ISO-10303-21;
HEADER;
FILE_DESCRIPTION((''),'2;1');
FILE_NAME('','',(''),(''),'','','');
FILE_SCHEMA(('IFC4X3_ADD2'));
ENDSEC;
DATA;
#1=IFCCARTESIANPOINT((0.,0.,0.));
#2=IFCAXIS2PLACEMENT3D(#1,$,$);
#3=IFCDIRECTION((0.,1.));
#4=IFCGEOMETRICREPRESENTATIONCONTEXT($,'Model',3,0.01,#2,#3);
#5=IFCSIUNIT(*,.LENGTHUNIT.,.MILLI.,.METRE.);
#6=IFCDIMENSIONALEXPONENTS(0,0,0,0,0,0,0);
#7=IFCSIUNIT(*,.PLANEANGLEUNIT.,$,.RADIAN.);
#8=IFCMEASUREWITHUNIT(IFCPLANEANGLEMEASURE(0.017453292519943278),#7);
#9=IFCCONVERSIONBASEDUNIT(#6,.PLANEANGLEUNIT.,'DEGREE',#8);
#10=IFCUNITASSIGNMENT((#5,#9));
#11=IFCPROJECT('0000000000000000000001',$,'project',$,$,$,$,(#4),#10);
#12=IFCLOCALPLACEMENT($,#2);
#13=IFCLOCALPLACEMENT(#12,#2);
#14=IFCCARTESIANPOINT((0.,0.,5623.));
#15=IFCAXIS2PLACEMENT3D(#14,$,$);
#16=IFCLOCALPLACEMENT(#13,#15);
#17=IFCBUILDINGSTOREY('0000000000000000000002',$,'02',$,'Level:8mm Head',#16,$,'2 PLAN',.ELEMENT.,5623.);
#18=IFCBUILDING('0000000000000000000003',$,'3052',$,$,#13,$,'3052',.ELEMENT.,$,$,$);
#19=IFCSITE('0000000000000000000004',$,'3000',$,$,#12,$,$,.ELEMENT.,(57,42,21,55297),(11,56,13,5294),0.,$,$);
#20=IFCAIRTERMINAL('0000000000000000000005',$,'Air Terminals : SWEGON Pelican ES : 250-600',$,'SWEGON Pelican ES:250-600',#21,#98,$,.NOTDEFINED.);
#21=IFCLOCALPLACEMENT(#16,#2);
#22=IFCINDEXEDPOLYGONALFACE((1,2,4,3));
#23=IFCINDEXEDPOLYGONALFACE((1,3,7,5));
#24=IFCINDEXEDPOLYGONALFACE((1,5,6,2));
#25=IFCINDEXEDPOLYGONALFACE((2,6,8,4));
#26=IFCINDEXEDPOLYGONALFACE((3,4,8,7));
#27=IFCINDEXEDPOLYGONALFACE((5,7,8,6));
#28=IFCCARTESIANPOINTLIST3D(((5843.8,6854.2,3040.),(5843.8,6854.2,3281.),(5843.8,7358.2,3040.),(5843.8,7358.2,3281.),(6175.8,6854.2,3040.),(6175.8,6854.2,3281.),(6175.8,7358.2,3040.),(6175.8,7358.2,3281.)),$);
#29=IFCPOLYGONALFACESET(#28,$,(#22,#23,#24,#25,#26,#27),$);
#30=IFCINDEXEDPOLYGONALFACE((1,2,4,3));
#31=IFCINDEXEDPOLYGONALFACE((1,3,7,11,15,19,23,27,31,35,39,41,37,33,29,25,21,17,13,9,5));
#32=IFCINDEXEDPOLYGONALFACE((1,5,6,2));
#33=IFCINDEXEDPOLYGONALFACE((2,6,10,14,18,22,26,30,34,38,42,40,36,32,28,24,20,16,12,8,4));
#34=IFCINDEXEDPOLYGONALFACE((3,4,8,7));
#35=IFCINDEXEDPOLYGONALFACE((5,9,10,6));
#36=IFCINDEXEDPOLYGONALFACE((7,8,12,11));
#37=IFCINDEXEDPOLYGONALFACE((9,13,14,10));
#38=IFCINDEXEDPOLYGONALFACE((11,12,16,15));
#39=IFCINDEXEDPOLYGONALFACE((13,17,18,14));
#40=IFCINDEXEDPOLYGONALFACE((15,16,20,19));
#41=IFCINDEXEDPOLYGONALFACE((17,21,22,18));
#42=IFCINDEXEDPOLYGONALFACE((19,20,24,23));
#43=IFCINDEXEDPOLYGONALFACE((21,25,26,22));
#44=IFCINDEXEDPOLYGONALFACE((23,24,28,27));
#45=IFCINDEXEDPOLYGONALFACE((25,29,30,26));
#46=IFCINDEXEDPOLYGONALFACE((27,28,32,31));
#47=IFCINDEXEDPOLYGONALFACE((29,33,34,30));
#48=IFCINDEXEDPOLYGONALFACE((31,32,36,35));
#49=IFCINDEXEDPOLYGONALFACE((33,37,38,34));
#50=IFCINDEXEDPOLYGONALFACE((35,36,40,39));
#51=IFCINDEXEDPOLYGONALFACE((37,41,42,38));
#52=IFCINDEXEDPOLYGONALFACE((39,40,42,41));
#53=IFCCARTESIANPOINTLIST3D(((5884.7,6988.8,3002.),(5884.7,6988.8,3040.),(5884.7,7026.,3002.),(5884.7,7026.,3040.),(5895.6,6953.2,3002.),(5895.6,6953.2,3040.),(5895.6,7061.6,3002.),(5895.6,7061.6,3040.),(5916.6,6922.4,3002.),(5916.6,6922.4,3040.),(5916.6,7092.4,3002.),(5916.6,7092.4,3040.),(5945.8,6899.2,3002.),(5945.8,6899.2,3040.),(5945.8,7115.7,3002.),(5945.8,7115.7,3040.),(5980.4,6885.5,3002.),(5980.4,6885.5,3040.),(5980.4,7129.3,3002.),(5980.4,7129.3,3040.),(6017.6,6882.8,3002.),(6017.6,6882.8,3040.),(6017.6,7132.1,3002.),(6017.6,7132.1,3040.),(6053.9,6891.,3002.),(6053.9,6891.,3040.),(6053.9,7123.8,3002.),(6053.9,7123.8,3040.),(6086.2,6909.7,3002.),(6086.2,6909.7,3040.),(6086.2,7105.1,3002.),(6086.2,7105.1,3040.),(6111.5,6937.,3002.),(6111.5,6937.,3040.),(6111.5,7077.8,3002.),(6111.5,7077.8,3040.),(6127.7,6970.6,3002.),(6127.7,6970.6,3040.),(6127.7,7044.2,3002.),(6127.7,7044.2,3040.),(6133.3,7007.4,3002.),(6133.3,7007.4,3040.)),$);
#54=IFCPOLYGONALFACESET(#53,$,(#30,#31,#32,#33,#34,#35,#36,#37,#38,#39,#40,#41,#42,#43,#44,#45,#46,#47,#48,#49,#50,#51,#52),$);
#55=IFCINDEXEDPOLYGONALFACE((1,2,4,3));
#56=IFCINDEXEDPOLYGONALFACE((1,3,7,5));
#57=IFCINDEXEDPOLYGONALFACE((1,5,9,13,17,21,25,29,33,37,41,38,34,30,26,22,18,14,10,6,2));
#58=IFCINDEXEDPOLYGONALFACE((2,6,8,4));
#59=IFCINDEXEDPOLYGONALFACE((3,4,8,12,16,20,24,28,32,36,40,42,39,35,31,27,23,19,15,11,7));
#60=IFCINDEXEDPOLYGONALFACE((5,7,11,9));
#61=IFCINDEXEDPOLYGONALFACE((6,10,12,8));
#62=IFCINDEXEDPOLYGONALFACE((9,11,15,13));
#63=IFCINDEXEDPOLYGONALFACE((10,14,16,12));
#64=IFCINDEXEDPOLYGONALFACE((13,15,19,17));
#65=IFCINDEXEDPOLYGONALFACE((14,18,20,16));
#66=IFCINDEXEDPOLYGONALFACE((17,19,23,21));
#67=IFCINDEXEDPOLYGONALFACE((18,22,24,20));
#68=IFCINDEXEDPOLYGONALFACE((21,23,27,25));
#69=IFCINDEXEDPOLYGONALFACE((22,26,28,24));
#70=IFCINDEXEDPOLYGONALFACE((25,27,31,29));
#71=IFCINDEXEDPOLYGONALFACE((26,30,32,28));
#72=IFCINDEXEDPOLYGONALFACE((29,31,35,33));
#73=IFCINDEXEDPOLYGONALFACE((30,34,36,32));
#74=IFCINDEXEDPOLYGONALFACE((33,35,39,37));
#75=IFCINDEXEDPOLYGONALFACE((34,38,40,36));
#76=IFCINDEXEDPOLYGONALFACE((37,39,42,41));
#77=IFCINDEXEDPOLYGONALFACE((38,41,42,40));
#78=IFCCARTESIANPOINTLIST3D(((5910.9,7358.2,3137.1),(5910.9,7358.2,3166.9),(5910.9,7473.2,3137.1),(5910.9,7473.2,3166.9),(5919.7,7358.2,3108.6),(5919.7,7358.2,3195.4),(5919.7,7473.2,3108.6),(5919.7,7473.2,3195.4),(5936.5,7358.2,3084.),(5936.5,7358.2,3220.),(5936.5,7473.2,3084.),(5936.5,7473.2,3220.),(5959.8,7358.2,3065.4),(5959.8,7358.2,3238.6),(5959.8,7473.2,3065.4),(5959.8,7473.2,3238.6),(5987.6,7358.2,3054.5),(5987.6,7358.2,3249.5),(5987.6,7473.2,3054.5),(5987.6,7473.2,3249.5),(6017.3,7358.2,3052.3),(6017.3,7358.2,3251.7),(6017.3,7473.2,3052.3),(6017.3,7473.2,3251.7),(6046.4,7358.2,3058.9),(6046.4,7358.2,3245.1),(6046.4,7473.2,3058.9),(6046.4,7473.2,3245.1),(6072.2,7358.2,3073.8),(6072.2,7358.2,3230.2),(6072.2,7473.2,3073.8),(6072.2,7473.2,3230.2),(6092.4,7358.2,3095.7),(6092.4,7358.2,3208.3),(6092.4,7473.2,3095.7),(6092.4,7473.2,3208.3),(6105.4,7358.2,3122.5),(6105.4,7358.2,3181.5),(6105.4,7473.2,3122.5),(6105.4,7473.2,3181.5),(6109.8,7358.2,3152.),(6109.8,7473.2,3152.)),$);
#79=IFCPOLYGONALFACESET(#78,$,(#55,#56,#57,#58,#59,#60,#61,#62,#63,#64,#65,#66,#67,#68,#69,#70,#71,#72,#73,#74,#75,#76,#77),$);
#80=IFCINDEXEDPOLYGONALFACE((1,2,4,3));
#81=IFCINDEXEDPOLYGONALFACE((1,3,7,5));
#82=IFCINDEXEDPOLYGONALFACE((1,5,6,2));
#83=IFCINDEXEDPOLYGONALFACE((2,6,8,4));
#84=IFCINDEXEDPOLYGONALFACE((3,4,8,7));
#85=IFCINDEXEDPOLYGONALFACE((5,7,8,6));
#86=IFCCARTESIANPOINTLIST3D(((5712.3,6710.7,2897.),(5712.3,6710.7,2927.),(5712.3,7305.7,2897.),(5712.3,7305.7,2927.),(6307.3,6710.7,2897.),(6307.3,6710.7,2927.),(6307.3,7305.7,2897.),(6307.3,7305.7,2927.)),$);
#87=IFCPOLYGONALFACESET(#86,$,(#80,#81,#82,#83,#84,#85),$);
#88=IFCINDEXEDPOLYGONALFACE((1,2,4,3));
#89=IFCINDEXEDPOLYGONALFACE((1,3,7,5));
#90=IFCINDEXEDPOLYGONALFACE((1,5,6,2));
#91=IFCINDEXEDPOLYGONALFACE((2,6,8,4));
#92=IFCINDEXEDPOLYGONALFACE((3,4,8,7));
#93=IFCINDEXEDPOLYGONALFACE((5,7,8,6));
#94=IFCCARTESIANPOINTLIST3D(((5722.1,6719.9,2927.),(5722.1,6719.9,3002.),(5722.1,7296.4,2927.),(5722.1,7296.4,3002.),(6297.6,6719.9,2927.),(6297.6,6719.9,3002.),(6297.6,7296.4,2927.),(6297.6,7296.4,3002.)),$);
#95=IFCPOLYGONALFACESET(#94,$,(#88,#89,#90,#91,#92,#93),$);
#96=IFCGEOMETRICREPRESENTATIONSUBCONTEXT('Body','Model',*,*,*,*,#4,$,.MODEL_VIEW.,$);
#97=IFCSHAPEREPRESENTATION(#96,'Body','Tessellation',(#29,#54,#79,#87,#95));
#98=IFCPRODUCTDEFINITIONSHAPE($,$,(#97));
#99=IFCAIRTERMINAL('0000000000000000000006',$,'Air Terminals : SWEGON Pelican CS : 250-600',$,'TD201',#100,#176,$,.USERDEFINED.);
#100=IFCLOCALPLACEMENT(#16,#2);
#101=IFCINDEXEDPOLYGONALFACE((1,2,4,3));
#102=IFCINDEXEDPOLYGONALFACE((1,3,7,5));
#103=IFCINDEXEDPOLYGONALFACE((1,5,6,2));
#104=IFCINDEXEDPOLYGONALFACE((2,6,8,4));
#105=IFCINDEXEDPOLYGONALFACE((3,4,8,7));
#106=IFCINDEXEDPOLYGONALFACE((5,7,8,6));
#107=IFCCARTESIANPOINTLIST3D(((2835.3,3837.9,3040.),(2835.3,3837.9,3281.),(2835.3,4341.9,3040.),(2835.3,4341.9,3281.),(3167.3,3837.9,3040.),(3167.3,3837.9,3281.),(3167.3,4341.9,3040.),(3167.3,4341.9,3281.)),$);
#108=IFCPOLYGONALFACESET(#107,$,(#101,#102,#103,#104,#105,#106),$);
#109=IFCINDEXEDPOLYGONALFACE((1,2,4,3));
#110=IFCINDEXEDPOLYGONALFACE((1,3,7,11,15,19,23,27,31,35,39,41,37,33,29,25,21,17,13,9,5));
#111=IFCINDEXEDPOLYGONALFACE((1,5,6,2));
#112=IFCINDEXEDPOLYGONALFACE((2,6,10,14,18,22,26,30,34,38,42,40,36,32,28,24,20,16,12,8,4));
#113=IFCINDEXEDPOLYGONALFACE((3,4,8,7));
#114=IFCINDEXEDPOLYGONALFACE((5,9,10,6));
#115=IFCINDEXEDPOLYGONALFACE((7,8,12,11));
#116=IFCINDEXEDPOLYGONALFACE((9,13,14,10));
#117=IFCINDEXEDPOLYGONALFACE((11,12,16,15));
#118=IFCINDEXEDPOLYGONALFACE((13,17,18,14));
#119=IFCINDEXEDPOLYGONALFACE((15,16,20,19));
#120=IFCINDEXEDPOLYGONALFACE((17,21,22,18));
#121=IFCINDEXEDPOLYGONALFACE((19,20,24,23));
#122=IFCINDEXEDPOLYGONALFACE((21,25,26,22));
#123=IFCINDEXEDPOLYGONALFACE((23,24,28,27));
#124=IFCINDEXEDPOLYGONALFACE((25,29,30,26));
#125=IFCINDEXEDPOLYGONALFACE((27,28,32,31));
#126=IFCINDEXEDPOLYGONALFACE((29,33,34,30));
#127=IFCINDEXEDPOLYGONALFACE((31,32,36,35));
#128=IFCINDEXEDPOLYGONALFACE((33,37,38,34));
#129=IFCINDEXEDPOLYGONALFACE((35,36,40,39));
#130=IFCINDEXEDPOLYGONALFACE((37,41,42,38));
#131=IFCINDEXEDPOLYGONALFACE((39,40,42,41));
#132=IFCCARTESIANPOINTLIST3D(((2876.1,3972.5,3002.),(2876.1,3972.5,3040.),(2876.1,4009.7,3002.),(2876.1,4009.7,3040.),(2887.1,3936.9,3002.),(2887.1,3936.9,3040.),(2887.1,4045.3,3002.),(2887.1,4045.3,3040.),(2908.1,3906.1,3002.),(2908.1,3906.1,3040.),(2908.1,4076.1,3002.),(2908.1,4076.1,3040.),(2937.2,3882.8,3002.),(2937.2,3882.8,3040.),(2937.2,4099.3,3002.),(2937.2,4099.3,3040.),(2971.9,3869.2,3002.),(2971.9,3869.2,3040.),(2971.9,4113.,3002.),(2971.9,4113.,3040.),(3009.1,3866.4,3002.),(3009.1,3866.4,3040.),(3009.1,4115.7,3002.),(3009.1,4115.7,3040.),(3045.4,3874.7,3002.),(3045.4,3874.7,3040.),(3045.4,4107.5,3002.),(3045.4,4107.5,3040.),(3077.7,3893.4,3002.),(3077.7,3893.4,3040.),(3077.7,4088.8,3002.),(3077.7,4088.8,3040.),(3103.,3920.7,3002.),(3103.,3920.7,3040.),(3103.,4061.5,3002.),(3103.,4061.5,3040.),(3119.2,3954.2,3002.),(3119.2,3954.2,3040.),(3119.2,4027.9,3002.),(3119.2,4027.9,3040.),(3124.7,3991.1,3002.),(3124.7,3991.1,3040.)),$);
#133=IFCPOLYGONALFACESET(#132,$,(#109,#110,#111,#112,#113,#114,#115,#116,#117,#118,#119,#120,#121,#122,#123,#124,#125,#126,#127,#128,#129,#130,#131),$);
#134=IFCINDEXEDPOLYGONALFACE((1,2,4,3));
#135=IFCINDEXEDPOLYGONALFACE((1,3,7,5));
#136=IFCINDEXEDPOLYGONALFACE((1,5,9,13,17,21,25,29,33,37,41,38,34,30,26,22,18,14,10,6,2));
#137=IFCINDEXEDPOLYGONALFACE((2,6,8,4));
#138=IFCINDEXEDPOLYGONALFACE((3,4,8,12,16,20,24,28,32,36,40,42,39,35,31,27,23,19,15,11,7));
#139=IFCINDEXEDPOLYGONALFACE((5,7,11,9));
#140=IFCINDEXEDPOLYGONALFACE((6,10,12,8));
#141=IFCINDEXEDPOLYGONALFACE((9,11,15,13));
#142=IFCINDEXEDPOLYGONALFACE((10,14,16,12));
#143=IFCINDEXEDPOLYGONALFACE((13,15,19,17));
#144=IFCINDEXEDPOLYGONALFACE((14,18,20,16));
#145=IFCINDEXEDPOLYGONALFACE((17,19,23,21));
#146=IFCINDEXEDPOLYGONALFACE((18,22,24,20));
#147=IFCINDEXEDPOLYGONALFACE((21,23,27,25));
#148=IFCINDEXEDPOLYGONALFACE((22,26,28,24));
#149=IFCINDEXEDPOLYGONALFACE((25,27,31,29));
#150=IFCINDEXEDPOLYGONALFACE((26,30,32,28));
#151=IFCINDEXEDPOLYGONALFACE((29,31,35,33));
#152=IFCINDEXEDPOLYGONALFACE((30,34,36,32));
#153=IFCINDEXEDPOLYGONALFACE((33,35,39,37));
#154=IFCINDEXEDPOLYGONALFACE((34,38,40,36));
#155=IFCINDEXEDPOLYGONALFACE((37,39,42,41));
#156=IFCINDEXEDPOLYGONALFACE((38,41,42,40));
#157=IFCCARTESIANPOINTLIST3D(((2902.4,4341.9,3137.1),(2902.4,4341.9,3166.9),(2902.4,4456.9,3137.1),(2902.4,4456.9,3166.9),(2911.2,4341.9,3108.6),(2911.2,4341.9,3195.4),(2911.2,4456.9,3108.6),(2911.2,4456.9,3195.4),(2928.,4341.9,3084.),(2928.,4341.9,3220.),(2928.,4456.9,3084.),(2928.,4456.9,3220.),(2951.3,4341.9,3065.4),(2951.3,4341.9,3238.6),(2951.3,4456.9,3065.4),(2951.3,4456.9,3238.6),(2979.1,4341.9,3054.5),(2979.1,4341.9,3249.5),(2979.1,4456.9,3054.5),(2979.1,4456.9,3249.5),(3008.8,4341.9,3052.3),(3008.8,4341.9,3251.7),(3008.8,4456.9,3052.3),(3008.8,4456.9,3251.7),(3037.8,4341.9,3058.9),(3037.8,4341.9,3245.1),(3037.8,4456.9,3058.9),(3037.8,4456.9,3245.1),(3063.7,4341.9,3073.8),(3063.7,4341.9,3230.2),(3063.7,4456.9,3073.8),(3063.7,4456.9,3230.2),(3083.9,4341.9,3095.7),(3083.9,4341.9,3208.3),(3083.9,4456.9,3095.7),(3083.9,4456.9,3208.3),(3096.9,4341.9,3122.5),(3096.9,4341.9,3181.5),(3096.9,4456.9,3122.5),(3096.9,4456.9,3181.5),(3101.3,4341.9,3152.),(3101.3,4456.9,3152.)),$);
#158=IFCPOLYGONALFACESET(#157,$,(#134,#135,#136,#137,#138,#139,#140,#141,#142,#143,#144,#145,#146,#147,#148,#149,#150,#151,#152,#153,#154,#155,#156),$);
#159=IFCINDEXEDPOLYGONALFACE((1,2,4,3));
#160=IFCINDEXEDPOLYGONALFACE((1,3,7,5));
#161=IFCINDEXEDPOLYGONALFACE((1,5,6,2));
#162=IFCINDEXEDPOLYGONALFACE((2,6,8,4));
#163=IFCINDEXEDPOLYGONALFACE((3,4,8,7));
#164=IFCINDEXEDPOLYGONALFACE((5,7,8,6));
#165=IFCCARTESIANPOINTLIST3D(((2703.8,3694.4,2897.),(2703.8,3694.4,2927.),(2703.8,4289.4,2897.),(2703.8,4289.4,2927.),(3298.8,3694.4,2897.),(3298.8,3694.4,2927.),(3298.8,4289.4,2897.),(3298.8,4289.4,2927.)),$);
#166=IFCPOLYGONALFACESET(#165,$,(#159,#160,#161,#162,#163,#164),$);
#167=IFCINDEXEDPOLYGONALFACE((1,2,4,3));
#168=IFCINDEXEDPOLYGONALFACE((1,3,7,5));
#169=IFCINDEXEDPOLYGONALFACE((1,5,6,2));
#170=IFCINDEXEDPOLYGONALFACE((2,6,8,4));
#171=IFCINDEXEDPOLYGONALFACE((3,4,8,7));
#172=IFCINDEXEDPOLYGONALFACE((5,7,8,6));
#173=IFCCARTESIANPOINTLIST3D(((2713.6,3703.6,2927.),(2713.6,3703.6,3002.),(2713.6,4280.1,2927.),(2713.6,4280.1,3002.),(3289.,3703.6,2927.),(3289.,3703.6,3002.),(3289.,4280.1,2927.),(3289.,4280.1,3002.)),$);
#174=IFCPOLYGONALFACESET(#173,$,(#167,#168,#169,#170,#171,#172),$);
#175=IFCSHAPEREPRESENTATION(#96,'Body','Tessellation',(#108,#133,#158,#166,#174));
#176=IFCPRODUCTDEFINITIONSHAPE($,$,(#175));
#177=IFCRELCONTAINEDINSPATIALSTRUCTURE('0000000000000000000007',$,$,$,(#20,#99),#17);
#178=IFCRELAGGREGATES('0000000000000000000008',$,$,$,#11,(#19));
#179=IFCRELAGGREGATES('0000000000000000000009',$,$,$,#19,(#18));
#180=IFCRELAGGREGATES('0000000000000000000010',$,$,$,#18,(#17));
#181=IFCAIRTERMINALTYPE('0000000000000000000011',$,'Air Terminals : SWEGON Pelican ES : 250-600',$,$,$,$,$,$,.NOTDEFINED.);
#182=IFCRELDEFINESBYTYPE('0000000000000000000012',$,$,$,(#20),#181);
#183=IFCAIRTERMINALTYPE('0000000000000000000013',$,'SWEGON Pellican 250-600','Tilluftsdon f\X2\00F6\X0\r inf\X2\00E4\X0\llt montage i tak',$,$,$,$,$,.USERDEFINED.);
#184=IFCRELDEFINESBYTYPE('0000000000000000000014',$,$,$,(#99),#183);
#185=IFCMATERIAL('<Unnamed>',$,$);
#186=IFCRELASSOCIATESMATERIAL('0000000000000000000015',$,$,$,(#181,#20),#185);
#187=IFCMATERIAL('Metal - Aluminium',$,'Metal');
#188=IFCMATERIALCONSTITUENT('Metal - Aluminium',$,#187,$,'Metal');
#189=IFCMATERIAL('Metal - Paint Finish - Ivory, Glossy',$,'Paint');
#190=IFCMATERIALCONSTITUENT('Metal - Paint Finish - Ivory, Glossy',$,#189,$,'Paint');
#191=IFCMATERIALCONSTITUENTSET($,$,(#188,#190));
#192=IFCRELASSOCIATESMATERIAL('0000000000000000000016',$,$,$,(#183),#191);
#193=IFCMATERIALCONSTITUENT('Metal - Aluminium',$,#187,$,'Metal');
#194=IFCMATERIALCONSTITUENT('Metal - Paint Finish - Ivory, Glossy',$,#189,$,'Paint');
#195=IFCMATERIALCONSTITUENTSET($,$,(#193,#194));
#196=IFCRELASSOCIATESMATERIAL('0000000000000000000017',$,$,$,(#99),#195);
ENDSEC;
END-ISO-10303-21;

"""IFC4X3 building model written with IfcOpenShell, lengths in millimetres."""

from ifc_helpers import new_model, entity, si_unit, converted_unit, direction, frame, frame_2d, origin, origin_2d_with_axis, place, context, subcontext, project, spatial, rectangle, circle, extrude, source, transform, mapped, material, constituent, constituent_set, type_object, type_shapes, element, save


model = new_model("IFC4X3")

# Units and contexts
model_context = context("Model", 3, precision=0.01, world=origin(), true_north=direction((0.0, 1.0)))
body_context = subcontext(model_context, "Body", "Model", "MODEL_VIEW")
ifc_project = project(units=[si_unit("LENGTHUNIT", "METRE", prefix="MILLI"), converted_unit("PLANEANGLEUNIT", "DEGREE", entity("IfcPlaneAngleMeasure", 0.017453292519943278), si_unit("PLANEANGLEUNIT", "RADIAN"), dimensions=[0, 0, 0, 0, 0, 0, 0])], contexts=[model_context])

# Site, building, storey
site_placement = place(None, origin())
site = spatial("IfcSite", under=ifc_project, at=site_placement, Name="3000", CompositionType="ELEMENT", RefLatitude=(57, 42, 21, 55297), RefLongitude=(11, 56, 13, 5294), RefElevation=0.0)
building_placement = place(site_placement, origin())
building = spatial("IfcBuilding", under=site, at=building_placement, Name="3052", LongName="3052", CompositionType="ELEMENT")
storey_placement = place(building_placement, frame((0.0, 0.0, 5623.0)))
storey = spatial("IfcBuildingStorey", under=building, at=storey_placement, Name="02", ObjectType="Level:8mm Head", LongName="2 PLAN", CompositionType="ELEMENT", Elevation=5623.0)

# Shared definitions
ifc_material_1 = material(Name="<Unnamed>")

# Air terminals
air_terminal_type_1 = type_object("IfcAirTerminalType", Name="Air Terminals : SWEGON Pelican ES : 250-600", PredefinedType="NOTDEFINED", material=ifc_material_1)
shared_shape_1 = source(origin(), body_context, "Body", "SweptSolid", [
    extrude(rectangle(XDim=504.0, YDim=332.0, at=origin_2d_with_axis()), frame((0.0, -98.0, -354.0), z_axis=(0.0, 0.0, 1.0), x_axis=(0.0, 1.0, 0.0)), (0.0, 0.0, 1.0), 241.0),
    extrude(circle(Radius=125.0, at=frame_2d((0.0, 0.0), x_axis=(1.0, 0.0))), frame((-1.6, 0.8, -113.0)), (0.0, 0.0, 1.0), 38.0),
    extrude(circle(Radius=100.0, at=frame_2d((0.0, 0.0), x_axis=(1.0, 0.0))), frame((0.0, -465.0, -225.0), z_axis=(0.0, 1.0, 0.0), x_axis=(1.0, 0.0, 0.0)), (0.0, 0.0, 1.0), 115.0),
    extrude(rectangle(XDim=595.0, YDim=595.0, at=frame_2d((0.0, 0.0), x_axis=(1.0, 0.0))), frame((0.0, 0.0, 0.0), z_axis=(0.0, 0.0, 1.0), x_axis=(0.0, 1.0, 0.0)), (0.0, 0.0, 1.0), 30.0),
    extrude(rectangle(XDim=576.5, YDim=575.5, at=origin_2d_with_axis()), frame((0.0, 0.0, -75.0), z_axis=(0.0, 0.0, 1.0), x_axis=(0.0, 1.0, 0.0)), (0.0, 0.0, 1.0), 75.0),
])
type_shapes(air_terminal_type_1, [shared_shape_1])
for number, where, z_axis, x_axis, name in (
    (1, (6009.8, 7008.2, 2927.0), (0.0, 0.0, -1.0), (1.0, 0.0, 0.0), "Air Terminals : SWEGON Pelican ES : 250-600"),
):
    element("IfcAirTerminal", number, at=place(storey_placement, frame(where, z_axis=z_axis, x_axis=x_axis)), inside=storey, type_object=air_terminal_type_1, material=ifc_material_1, Name=name, ObjectType="SWEGON Pelican ES:250-600", PredefinedType="NOTDEFINED", context=body_context, shape_type="MappedRepresentation", body=[
        mapped(shared_shape_1, transform((0.0, 0.0, 0.0), scale=1.0)),
    ])
ifc_material_2 = material(Name="Metal - Aluminium", Category="Metal")
ifc_constituent_1 = constituent(ifc_material_2, Name="Metal - Aluminium", Category="Metal")
ifc_material_3 = material(Name="Metal - Paint Finish - Ivory, Glossy", Category="Paint")
ifc_constituent_2 = constituent(ifc_material_3, Name="Metal - Paint Finish - Ivory, Glossy", Category="Paint")
ifc_constituent_set_1 = constituent_set(constituents=[ifc_constituent_1, ifc_constituent_2])
ifc_constituent_3 = constituent(ifc_material_2, Name="Metal - Aluminium", Category="Metal")
ifc_constituent_4 = constituent(ifc_material_3, Name="Metal - Paint Finish - Ivory, Glossy", Category="Paint")
ifc_constituent_set_2 = constituent_set(constituents=[ifc_constituent_3, ifc_constituent_4])
air_terminal_type_2 = type_object("IfcAirTerminalType", Name="SWEGON Pellican 250-600", Description="Tilluftsdon för infällt montage i tak", PredefinedType="USERDEFINED", material=ifc_constituent_set_2)
shared_shape_2 = source(origin(), body_context, "Body", "SweptSolid", [
    extrude(rectangle(XDim=504.0, YDim=332.0, at=origin_2d_with_axis()), frame((0.0, -98.0, -354.0), z_axis=(0.0, 0.0, 1.0), x_axis=(0.0, 1.0, 0.0)), (0.0, 0.0, 1.0), 241.0),
    extrude(circle(Radius=125.0, at=frame_2d((0.0, 0.0), x_axis=(1.0, 0.0))), frame((-1.6, 0.8, -113.0)), (0.0, 0.0, 1.0), 38.0),
    extrude(circle(Radius=100.0, at=frame_2d((0.0, 0.0), x_axis=(1.0, 0.0))), frame((0.0, -465.0, -225.0), z_axis=(0.0, 1.0, 0.0), x_axis=(1.0, 0.0, 0.0)), (0.0, 0.0, 1.0), 115.0),
    extrude(rectangle(XDim=595.0, YDim=595.0, at=frame_2d((0.0, 0.0), x_axis=(1.0, 0.0))), frame((0.0, 0.0, 0.0), z_axis=(0.0, 0.0, 1.0), x_axis=(0.0, 1.0, 0.0)), (0.0, 0.0, 1.0), 30.0),
    extrude(rectangle(XDim=576.5, YDim=575.5, at=origin_2d_with_axis()), frame((0.0, 0.0, -75.0), z_axis=(0.0, 0.0, 1.0), x_axis=(0.0, 1.0, 0.0)), (0.0, 0.0, 1.0), 75.0),
])
type_shapes(air_terminal_type_2, [shared_shape_2])
air_terminal_1_placement = place(storey_placement, frame((3001.3, 3991.9, 2927.0), z_axis=(0.0, 0.0, -1.0), x_axis=(1.0, 0.0, 0.0)))
element("IfcAirTerminal", 2, at=air_terminal_1_placement, inside=storey, type_object=air_terminal_type_2, material=ifc_constituent_set_1, Name="Air Terminals : SWEGON Pelican CS : 250-600", ObjectType="TD201", PredefinedType="USERDEFINED", context=body_context, shape_type="MappedRepresentation", body=[
    mapped(shared_shape_2, transform((0.0, 0.0, 0.0), scale=1.0)),
])

save(model, "model.ifc")
